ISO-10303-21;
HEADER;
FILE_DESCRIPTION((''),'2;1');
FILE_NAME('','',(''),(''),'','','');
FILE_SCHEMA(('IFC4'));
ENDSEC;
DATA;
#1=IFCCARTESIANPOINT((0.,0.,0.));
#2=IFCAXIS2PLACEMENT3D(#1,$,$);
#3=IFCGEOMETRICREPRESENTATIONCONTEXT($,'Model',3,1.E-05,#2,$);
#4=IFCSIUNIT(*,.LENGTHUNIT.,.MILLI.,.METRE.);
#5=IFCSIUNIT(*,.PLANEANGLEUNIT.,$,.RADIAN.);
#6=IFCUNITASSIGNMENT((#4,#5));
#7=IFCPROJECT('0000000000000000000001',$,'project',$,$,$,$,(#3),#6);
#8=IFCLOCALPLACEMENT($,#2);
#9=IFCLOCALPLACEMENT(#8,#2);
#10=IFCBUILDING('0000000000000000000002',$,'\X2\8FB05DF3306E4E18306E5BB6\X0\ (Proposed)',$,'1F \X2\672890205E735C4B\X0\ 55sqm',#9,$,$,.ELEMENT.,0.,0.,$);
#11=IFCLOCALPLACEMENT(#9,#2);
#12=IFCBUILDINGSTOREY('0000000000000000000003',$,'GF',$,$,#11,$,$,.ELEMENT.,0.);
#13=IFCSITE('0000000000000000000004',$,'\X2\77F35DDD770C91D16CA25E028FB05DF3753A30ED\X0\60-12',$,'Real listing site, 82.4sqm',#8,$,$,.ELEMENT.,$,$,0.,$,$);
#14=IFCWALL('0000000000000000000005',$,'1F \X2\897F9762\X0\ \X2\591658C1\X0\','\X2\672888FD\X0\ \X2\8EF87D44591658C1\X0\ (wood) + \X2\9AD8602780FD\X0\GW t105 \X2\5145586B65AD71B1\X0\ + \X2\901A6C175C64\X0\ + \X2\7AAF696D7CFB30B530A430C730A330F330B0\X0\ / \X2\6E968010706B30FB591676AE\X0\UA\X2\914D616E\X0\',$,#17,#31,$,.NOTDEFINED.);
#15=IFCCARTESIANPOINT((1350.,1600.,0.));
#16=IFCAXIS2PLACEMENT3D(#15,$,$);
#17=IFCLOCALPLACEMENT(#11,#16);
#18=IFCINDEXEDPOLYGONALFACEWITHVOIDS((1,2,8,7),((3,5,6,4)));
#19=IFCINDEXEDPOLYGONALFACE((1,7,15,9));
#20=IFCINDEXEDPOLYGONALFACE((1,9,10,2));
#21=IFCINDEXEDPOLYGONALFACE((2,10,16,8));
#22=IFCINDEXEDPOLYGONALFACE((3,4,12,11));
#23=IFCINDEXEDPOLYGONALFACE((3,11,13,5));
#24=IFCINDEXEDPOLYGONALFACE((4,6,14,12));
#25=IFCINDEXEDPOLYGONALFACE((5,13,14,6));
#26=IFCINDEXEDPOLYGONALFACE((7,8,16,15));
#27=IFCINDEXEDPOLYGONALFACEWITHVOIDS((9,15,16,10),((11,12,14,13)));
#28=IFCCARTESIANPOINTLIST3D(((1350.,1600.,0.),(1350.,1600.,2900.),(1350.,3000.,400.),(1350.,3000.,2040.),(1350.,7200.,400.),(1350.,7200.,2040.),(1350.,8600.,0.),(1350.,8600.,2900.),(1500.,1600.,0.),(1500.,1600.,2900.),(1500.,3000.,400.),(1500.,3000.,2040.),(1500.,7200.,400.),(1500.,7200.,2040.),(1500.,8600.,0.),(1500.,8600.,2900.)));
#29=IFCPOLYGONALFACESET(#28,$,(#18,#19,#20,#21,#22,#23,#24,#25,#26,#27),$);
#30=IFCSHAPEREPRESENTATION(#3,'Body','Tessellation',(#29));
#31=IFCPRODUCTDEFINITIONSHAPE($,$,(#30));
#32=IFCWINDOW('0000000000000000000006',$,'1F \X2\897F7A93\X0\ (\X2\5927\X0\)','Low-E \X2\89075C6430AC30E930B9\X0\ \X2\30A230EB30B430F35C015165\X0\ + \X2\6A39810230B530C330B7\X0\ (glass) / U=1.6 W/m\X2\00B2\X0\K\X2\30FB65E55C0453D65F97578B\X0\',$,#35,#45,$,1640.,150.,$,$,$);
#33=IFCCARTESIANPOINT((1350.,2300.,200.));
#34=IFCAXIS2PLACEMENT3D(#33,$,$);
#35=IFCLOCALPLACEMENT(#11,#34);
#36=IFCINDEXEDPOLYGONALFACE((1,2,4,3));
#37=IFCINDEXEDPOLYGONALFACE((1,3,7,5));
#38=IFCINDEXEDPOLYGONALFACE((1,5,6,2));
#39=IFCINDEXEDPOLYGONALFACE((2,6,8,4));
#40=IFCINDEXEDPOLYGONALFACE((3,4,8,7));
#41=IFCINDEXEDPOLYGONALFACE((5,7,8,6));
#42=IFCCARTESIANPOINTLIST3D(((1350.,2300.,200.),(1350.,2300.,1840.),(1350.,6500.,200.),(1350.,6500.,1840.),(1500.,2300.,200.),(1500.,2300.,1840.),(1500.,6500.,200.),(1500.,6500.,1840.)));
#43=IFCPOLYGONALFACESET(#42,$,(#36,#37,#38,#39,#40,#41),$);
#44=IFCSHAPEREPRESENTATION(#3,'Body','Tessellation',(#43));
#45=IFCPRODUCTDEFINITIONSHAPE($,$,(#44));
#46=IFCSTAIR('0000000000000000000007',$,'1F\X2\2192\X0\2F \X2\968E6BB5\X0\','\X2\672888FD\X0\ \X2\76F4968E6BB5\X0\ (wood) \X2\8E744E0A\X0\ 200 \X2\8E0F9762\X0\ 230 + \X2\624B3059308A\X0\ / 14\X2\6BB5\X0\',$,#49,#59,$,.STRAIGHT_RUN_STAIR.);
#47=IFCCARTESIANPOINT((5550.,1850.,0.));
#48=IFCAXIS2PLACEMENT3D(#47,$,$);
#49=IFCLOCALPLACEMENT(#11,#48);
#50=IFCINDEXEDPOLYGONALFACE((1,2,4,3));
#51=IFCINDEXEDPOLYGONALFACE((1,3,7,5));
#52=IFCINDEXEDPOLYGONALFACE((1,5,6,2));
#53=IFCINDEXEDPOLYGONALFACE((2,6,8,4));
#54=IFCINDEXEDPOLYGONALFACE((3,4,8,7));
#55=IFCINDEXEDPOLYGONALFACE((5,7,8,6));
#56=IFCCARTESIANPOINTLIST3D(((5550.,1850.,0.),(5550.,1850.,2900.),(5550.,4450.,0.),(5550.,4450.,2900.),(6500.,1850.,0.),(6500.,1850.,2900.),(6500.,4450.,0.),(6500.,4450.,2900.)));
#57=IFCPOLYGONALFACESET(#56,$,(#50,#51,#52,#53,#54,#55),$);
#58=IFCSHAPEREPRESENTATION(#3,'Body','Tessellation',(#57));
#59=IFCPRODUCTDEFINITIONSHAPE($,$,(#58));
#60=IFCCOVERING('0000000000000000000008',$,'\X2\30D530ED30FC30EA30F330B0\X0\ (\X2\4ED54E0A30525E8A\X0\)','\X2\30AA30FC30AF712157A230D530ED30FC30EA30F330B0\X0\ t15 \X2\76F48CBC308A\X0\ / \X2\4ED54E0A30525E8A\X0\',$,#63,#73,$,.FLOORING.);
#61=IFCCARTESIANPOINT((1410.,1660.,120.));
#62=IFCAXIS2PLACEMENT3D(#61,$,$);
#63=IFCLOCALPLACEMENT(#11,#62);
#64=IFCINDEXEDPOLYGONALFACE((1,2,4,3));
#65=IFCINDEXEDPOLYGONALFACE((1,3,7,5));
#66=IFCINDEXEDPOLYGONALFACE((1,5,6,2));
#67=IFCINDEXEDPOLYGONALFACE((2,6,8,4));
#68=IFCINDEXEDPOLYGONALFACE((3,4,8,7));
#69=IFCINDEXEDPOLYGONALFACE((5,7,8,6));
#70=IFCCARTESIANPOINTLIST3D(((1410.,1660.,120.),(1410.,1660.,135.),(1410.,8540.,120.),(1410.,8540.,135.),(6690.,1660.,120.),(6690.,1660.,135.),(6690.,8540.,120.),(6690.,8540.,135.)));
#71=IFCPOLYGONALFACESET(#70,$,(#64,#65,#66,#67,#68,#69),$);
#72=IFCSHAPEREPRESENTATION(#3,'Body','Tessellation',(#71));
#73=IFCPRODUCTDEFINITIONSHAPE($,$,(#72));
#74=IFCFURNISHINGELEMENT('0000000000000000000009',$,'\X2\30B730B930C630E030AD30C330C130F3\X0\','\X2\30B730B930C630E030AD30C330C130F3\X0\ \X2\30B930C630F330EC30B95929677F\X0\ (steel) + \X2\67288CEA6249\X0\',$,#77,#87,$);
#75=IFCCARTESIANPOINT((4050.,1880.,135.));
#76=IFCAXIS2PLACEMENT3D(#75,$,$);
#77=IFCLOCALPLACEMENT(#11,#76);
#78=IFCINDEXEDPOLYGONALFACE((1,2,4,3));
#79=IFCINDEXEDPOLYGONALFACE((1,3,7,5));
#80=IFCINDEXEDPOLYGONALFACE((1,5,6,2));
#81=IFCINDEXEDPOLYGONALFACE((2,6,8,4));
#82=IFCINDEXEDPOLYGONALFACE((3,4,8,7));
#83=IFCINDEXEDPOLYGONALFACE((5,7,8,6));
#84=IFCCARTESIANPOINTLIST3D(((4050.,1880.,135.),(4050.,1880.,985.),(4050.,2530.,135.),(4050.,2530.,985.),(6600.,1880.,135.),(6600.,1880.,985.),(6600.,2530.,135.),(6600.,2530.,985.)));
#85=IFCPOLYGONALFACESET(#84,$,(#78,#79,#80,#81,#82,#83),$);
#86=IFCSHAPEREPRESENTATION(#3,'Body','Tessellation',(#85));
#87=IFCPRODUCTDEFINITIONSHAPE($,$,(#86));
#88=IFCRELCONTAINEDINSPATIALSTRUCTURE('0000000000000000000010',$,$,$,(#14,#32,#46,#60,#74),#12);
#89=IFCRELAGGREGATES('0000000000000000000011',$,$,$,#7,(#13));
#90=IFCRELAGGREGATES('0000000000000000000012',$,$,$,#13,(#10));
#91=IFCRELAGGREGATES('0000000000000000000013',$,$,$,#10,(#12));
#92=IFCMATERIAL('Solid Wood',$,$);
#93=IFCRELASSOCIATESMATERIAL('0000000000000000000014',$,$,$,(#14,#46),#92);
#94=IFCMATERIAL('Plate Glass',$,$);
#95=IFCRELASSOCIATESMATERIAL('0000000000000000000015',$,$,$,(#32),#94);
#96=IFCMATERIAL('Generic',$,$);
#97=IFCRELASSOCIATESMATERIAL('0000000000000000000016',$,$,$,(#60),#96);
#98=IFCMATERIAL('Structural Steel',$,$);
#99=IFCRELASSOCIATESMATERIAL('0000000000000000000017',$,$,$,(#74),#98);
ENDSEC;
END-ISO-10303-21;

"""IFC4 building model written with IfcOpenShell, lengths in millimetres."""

from ifc_helpers import new_model, si_unit, frame, frame_2d, origin, place, context, project, spatial, rectangle, extrude, material, element, fill, save


model = new_model("IFC4")

# Units and contexts
model_context = context("Model", 3, precision=1e-05, world=origin())
ifc_project = project(units=[si_unit("LENGTHUNIT", "METRE", prefix="MILLI"), si_unit("PLANEANGLEUNIT", "RADIAN")], contexts=[model_context])

# Site, building, storey
site_placement = place(None, origin())
site = spatial("IfcSite", under=ifc_project, at=site_placement, Name="石川県金沢市辰巳町ロ60-12", ObjectType="Real listing site, 82.4sqm", CompositionType="ELEMENT", RefElevation=0.0)
building_placement = place(site_placement, origin())
building = spatial("IfcBuilding", under=site, at=building_placement, Name="辰巳の丘の家 (Proposed)", ObjectType="1F 木造平屋 55sqm", CompositionType="ELEMENT", ElevationOfRefHeight=0.0, ElevationOfTerrain=0.0)
storey_placement = place(building_placement, origin())
storey = spatial("IfcBuildingStorey", under=building, at=storey_placement, Name="GF", CompositionType="ELEMENT", Elevation=0.0)

# Shared definitions
ifc_material_1 = material(Name="Solid Wood")
ifc_material_2 = material(Name="Generic")

# Shared definitions
ifc_material_3 = material(Name="Plate Glass")

# Wall, opening, window
wall_1_placement = place(storey_placement, frame((1350.0, 1600.0, 0.0)))
wall_1 = element("IfcWall", 1, at=wall_1_placement, inside=storey, material=ifc_material_1, Name="1F 西面 外壁", Description="木製 軸組外壁 (wood) + 高性能GW t105 充填断熱 + 通気層 + 窯業系サイディング / 準耐火・外皮UA配慮", PredefinedType="NOTDEFINED", context=model_context, shape_type="SweptSolid", body=[
    extrude(rectangle(XDim=150.0, YDim=7000.0, at=frame_2d((75.0, 3500.0))), frame((1350.0, 1600.0, 0.0)), (0.0, 0.0, 1.0), 2900.0),
])
opening_1_placement = place(storey_placement, frame((1350.0, 2300.0, 200.0)))
opening_1 = element("IfcOpeningElement", 2, at=opening_1_placement, cuts=wall_1, PredefinedType="NOTDEFINED", context=model_context, shape_type="SweptSolid", body=[
    extrude(rectangle(XDim=150.0, YDim=4200.0, at=frame_2d((75.0, 2100.0))), frame((1350.0, 2300.0, 200.0)), (0.0, 0.0, 1.0), 1640.0),
])
window_1_placement = place(storey_placement, frame((1350.0, 2300.0, 200.0)))
window_1 = element("IfcWindow", 3, at=window_1_placement, inside=storey, material=ifc_material_3, Name="1F 西窓 (大)", Description="Low-E 複層ガラス アルゴン封入 + 樹脂サッシ (glass) / U=1.6 W/m²K・日射取得型", OverallHeight=1640.0, OverallWidth=150.0, context=model_context, shape_type="SweptSolid", body=[
    extrude(rectangle(XDim=150.0, YDim=4200.0, at=frame_2d((75.0, 2100.0))), frame((1350.0, 2300.0, 200.0)), (0.0, 0.0, 1.0), 1640.0),
])
fill(opening_1, window_1)

# Stair
stair_placement = place(storey_placement, frame((5550.0, 1850.0, 0.0)))
element("IfcStair", 4, at=stair_placement, inside=storey, material=ifc_material_1, Name="1F→2F 階段", Description="木製 直階段 (wood) 蹴上 200 踏面 230 + 手すり / 14段", PredefinedType="STRAIGHT_RUN_STAIR", context=model_context, shape_type="SweptSolid", body=[
    extrude(rectangle(XDim=950.0, YDim=2600.0, at=frame_2d((475.0, 1300.0))), frame((5550.0, 1850.0, 0.0)), (0.0, 0.0, 1.0), 2900.0),
])

# Covering
covering_placement = place(storey_placement, frame((1410.0, 1660.0, 120.0)))
element("IfcCovering", 5, at=covering_placement, inside=storey, material=ifc_material_2, Name="フローリング (仕上げ床)", Description="オーク無垢フローリング t15 直貼り / 仕上げ床", PredefinedType="FLOORING", context=model_context, shape_type="SweptSolid", body=[
    extrude(rectangle(XDim=5280.0, YDim=6880.0, at=frame_2d((2640.0, 3440.0))), frame((1410.0, 1660.0, 120.0)), (0.0, 0.0, 1.0), 15.0),
])

# Furnishing element
ifc_material_4 = material(Name="Structural Steel")
furnishing_placement = place(storey_placement, frame((4050.0, 1880.0, 135.0)))
element("IfcFurnishingElement", 6, at=furnishing_placement, inside=storey, material=ifc_material_4, Name="システムキッチン", Description="システムキッチン ステンレス天板 (steel) + 木質扉", context=model_context, shape_type="SweptSolid", body=[
    extrude(rectangle(XDim=2550.0, YDim=650.0, at=frame_2d((1275.0, 325.0))), frame((4050.0, 1880.0, 135.0)), (0.0, 0.0, 1.0), 850.0),
])

save(model, "model.ifc")
